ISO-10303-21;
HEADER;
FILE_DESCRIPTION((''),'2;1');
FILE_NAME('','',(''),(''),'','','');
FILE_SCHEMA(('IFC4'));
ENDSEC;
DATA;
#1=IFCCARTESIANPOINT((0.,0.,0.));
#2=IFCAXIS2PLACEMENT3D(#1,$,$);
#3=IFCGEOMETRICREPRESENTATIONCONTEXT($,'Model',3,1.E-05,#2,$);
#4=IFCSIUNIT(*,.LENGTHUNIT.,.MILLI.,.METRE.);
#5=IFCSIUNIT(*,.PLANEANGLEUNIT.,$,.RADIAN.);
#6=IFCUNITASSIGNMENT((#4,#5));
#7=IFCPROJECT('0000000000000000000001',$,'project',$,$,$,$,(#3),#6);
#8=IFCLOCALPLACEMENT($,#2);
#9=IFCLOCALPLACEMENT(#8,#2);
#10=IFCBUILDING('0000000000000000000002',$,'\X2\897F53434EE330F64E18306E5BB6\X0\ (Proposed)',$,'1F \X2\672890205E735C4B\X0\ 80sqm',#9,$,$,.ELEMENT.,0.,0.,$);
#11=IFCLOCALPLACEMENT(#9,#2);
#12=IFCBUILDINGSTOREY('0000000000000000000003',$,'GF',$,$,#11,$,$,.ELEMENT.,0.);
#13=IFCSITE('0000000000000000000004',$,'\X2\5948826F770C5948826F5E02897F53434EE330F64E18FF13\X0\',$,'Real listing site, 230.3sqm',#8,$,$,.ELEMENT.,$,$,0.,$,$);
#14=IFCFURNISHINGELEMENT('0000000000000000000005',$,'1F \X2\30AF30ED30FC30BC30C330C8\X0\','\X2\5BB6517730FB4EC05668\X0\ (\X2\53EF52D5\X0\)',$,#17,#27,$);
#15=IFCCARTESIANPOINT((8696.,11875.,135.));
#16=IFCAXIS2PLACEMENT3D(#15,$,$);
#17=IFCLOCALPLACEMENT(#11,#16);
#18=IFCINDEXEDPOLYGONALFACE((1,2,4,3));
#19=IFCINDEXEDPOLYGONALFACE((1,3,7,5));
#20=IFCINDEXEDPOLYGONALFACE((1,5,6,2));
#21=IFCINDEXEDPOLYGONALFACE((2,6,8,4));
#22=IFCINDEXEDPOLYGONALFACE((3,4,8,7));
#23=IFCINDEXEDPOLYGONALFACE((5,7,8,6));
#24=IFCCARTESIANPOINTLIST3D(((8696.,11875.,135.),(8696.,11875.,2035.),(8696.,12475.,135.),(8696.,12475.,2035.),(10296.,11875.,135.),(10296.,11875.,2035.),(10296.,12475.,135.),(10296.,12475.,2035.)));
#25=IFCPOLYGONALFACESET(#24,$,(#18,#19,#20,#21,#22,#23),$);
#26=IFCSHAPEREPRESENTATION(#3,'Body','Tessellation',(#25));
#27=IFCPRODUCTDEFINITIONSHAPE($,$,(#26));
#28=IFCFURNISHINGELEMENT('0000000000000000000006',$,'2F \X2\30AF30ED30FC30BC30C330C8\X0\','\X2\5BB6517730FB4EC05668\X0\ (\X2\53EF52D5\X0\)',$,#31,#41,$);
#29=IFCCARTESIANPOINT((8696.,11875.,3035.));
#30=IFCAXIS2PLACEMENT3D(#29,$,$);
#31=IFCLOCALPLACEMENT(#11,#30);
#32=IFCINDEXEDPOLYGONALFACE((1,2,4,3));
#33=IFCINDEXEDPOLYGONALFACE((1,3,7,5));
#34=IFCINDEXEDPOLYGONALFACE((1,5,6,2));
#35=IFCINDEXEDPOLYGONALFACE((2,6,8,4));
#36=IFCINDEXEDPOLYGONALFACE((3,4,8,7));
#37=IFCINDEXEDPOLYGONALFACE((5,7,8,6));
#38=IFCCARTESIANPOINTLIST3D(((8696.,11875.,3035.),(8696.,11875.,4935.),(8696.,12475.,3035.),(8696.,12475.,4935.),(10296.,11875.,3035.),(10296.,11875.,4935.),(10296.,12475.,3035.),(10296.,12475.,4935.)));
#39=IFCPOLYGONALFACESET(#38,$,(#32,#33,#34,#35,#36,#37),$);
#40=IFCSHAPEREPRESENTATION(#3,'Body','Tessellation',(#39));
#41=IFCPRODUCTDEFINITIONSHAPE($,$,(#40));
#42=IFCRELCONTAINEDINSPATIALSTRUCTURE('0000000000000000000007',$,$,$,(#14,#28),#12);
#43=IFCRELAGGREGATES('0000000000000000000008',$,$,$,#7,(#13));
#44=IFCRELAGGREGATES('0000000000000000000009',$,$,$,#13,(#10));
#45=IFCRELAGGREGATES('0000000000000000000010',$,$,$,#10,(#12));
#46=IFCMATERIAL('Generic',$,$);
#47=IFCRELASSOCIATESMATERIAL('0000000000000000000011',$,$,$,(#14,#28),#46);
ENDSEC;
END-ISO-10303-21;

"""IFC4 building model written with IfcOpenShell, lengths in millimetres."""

from ifc_helpers import new_model, si_unit, frame, frame_2d, origin, place, context, project, spatial, rectangle, extrude, material, element, save


model = new_model("IFC4")

# Units and contexts
model_context = context("Model", 3, precision=1e-05, world=origin())
ifc_project = project(units=[si_unit("LENGTHUNIT", "METRE", prefix="MILLI"), si_unit("PLANEANGLEUNIT", "RADIAN")], contexts=[model_context])

# Site, building, storey
site_placement = place(None, origin())
site = spatial("IfcSite", under=ifc_project, at=site_placement, Name="奈良県奈良市西千代ヶ丘３", ObjectType="Real listing site, 230.3sqm", CompositionType="ELEMENT", RefElevation=0.0)
building_placement = place(site_placement, origin())
building = spatial("IfcBuilding", under=site, at=building_placement, Name="西千代ヶ丘の家 (Proposed)", ObjectType="1F 木造平屋 80sqm", CompositionType="ELEMENT", ElevationOfRefHeight=0.0, ElevationOfTerrain=0.0)
storey_placement = place(building_placement, origin())
storey = spatial("IfcBuildingStorey", under=building, at=storey_placement, Name="GF", CompositionType="ELEMENT", Elevation=0.0)

# Shared definitions
ifc_material_1 = material(Name="Generic")

# Furnishing elements
furnishing_1_placement = place(storey_placement, frame((8696.0, 11875.0, 135.0)))
element("IfcFurnishingElement", 1, at=furnishing_1_placement, inside=storey, material=ifc_material_1, Name="1F クローゼット", Description="家具・什器 (可動)", context=model_context, shape_type="SweptSolid", body=[
    extrude(rectangle(XDim=1600.0, YDim=600.0, at=frame_2d((800.0, 300.0))), frame((8696.0, 11875.0, 135.0)), (0.0, 0.0, 1.0), 1900.0),
])
furnishing_2_placement = place(storey_placement, frame((8696.0, 11875.0, 3035.0)))
element("IfcFurnishingElement", 2, at=furnishing_2_placement, inside=storey, material=ifc_material_1, Name="2F クローゼット", Description="家具・什器 (可動)", context=model_context, shape_type="SweptSolid", body=[
    extrude(rectangle(XDim=1600.0, YDim=600.0, at=frame_2d((800.0, 300.0))), frame((8696.0, 11875.0, 3035.0)), (0.0, 0.0, 1.0), 1900.0),
])

save(model, "model.ifc")
